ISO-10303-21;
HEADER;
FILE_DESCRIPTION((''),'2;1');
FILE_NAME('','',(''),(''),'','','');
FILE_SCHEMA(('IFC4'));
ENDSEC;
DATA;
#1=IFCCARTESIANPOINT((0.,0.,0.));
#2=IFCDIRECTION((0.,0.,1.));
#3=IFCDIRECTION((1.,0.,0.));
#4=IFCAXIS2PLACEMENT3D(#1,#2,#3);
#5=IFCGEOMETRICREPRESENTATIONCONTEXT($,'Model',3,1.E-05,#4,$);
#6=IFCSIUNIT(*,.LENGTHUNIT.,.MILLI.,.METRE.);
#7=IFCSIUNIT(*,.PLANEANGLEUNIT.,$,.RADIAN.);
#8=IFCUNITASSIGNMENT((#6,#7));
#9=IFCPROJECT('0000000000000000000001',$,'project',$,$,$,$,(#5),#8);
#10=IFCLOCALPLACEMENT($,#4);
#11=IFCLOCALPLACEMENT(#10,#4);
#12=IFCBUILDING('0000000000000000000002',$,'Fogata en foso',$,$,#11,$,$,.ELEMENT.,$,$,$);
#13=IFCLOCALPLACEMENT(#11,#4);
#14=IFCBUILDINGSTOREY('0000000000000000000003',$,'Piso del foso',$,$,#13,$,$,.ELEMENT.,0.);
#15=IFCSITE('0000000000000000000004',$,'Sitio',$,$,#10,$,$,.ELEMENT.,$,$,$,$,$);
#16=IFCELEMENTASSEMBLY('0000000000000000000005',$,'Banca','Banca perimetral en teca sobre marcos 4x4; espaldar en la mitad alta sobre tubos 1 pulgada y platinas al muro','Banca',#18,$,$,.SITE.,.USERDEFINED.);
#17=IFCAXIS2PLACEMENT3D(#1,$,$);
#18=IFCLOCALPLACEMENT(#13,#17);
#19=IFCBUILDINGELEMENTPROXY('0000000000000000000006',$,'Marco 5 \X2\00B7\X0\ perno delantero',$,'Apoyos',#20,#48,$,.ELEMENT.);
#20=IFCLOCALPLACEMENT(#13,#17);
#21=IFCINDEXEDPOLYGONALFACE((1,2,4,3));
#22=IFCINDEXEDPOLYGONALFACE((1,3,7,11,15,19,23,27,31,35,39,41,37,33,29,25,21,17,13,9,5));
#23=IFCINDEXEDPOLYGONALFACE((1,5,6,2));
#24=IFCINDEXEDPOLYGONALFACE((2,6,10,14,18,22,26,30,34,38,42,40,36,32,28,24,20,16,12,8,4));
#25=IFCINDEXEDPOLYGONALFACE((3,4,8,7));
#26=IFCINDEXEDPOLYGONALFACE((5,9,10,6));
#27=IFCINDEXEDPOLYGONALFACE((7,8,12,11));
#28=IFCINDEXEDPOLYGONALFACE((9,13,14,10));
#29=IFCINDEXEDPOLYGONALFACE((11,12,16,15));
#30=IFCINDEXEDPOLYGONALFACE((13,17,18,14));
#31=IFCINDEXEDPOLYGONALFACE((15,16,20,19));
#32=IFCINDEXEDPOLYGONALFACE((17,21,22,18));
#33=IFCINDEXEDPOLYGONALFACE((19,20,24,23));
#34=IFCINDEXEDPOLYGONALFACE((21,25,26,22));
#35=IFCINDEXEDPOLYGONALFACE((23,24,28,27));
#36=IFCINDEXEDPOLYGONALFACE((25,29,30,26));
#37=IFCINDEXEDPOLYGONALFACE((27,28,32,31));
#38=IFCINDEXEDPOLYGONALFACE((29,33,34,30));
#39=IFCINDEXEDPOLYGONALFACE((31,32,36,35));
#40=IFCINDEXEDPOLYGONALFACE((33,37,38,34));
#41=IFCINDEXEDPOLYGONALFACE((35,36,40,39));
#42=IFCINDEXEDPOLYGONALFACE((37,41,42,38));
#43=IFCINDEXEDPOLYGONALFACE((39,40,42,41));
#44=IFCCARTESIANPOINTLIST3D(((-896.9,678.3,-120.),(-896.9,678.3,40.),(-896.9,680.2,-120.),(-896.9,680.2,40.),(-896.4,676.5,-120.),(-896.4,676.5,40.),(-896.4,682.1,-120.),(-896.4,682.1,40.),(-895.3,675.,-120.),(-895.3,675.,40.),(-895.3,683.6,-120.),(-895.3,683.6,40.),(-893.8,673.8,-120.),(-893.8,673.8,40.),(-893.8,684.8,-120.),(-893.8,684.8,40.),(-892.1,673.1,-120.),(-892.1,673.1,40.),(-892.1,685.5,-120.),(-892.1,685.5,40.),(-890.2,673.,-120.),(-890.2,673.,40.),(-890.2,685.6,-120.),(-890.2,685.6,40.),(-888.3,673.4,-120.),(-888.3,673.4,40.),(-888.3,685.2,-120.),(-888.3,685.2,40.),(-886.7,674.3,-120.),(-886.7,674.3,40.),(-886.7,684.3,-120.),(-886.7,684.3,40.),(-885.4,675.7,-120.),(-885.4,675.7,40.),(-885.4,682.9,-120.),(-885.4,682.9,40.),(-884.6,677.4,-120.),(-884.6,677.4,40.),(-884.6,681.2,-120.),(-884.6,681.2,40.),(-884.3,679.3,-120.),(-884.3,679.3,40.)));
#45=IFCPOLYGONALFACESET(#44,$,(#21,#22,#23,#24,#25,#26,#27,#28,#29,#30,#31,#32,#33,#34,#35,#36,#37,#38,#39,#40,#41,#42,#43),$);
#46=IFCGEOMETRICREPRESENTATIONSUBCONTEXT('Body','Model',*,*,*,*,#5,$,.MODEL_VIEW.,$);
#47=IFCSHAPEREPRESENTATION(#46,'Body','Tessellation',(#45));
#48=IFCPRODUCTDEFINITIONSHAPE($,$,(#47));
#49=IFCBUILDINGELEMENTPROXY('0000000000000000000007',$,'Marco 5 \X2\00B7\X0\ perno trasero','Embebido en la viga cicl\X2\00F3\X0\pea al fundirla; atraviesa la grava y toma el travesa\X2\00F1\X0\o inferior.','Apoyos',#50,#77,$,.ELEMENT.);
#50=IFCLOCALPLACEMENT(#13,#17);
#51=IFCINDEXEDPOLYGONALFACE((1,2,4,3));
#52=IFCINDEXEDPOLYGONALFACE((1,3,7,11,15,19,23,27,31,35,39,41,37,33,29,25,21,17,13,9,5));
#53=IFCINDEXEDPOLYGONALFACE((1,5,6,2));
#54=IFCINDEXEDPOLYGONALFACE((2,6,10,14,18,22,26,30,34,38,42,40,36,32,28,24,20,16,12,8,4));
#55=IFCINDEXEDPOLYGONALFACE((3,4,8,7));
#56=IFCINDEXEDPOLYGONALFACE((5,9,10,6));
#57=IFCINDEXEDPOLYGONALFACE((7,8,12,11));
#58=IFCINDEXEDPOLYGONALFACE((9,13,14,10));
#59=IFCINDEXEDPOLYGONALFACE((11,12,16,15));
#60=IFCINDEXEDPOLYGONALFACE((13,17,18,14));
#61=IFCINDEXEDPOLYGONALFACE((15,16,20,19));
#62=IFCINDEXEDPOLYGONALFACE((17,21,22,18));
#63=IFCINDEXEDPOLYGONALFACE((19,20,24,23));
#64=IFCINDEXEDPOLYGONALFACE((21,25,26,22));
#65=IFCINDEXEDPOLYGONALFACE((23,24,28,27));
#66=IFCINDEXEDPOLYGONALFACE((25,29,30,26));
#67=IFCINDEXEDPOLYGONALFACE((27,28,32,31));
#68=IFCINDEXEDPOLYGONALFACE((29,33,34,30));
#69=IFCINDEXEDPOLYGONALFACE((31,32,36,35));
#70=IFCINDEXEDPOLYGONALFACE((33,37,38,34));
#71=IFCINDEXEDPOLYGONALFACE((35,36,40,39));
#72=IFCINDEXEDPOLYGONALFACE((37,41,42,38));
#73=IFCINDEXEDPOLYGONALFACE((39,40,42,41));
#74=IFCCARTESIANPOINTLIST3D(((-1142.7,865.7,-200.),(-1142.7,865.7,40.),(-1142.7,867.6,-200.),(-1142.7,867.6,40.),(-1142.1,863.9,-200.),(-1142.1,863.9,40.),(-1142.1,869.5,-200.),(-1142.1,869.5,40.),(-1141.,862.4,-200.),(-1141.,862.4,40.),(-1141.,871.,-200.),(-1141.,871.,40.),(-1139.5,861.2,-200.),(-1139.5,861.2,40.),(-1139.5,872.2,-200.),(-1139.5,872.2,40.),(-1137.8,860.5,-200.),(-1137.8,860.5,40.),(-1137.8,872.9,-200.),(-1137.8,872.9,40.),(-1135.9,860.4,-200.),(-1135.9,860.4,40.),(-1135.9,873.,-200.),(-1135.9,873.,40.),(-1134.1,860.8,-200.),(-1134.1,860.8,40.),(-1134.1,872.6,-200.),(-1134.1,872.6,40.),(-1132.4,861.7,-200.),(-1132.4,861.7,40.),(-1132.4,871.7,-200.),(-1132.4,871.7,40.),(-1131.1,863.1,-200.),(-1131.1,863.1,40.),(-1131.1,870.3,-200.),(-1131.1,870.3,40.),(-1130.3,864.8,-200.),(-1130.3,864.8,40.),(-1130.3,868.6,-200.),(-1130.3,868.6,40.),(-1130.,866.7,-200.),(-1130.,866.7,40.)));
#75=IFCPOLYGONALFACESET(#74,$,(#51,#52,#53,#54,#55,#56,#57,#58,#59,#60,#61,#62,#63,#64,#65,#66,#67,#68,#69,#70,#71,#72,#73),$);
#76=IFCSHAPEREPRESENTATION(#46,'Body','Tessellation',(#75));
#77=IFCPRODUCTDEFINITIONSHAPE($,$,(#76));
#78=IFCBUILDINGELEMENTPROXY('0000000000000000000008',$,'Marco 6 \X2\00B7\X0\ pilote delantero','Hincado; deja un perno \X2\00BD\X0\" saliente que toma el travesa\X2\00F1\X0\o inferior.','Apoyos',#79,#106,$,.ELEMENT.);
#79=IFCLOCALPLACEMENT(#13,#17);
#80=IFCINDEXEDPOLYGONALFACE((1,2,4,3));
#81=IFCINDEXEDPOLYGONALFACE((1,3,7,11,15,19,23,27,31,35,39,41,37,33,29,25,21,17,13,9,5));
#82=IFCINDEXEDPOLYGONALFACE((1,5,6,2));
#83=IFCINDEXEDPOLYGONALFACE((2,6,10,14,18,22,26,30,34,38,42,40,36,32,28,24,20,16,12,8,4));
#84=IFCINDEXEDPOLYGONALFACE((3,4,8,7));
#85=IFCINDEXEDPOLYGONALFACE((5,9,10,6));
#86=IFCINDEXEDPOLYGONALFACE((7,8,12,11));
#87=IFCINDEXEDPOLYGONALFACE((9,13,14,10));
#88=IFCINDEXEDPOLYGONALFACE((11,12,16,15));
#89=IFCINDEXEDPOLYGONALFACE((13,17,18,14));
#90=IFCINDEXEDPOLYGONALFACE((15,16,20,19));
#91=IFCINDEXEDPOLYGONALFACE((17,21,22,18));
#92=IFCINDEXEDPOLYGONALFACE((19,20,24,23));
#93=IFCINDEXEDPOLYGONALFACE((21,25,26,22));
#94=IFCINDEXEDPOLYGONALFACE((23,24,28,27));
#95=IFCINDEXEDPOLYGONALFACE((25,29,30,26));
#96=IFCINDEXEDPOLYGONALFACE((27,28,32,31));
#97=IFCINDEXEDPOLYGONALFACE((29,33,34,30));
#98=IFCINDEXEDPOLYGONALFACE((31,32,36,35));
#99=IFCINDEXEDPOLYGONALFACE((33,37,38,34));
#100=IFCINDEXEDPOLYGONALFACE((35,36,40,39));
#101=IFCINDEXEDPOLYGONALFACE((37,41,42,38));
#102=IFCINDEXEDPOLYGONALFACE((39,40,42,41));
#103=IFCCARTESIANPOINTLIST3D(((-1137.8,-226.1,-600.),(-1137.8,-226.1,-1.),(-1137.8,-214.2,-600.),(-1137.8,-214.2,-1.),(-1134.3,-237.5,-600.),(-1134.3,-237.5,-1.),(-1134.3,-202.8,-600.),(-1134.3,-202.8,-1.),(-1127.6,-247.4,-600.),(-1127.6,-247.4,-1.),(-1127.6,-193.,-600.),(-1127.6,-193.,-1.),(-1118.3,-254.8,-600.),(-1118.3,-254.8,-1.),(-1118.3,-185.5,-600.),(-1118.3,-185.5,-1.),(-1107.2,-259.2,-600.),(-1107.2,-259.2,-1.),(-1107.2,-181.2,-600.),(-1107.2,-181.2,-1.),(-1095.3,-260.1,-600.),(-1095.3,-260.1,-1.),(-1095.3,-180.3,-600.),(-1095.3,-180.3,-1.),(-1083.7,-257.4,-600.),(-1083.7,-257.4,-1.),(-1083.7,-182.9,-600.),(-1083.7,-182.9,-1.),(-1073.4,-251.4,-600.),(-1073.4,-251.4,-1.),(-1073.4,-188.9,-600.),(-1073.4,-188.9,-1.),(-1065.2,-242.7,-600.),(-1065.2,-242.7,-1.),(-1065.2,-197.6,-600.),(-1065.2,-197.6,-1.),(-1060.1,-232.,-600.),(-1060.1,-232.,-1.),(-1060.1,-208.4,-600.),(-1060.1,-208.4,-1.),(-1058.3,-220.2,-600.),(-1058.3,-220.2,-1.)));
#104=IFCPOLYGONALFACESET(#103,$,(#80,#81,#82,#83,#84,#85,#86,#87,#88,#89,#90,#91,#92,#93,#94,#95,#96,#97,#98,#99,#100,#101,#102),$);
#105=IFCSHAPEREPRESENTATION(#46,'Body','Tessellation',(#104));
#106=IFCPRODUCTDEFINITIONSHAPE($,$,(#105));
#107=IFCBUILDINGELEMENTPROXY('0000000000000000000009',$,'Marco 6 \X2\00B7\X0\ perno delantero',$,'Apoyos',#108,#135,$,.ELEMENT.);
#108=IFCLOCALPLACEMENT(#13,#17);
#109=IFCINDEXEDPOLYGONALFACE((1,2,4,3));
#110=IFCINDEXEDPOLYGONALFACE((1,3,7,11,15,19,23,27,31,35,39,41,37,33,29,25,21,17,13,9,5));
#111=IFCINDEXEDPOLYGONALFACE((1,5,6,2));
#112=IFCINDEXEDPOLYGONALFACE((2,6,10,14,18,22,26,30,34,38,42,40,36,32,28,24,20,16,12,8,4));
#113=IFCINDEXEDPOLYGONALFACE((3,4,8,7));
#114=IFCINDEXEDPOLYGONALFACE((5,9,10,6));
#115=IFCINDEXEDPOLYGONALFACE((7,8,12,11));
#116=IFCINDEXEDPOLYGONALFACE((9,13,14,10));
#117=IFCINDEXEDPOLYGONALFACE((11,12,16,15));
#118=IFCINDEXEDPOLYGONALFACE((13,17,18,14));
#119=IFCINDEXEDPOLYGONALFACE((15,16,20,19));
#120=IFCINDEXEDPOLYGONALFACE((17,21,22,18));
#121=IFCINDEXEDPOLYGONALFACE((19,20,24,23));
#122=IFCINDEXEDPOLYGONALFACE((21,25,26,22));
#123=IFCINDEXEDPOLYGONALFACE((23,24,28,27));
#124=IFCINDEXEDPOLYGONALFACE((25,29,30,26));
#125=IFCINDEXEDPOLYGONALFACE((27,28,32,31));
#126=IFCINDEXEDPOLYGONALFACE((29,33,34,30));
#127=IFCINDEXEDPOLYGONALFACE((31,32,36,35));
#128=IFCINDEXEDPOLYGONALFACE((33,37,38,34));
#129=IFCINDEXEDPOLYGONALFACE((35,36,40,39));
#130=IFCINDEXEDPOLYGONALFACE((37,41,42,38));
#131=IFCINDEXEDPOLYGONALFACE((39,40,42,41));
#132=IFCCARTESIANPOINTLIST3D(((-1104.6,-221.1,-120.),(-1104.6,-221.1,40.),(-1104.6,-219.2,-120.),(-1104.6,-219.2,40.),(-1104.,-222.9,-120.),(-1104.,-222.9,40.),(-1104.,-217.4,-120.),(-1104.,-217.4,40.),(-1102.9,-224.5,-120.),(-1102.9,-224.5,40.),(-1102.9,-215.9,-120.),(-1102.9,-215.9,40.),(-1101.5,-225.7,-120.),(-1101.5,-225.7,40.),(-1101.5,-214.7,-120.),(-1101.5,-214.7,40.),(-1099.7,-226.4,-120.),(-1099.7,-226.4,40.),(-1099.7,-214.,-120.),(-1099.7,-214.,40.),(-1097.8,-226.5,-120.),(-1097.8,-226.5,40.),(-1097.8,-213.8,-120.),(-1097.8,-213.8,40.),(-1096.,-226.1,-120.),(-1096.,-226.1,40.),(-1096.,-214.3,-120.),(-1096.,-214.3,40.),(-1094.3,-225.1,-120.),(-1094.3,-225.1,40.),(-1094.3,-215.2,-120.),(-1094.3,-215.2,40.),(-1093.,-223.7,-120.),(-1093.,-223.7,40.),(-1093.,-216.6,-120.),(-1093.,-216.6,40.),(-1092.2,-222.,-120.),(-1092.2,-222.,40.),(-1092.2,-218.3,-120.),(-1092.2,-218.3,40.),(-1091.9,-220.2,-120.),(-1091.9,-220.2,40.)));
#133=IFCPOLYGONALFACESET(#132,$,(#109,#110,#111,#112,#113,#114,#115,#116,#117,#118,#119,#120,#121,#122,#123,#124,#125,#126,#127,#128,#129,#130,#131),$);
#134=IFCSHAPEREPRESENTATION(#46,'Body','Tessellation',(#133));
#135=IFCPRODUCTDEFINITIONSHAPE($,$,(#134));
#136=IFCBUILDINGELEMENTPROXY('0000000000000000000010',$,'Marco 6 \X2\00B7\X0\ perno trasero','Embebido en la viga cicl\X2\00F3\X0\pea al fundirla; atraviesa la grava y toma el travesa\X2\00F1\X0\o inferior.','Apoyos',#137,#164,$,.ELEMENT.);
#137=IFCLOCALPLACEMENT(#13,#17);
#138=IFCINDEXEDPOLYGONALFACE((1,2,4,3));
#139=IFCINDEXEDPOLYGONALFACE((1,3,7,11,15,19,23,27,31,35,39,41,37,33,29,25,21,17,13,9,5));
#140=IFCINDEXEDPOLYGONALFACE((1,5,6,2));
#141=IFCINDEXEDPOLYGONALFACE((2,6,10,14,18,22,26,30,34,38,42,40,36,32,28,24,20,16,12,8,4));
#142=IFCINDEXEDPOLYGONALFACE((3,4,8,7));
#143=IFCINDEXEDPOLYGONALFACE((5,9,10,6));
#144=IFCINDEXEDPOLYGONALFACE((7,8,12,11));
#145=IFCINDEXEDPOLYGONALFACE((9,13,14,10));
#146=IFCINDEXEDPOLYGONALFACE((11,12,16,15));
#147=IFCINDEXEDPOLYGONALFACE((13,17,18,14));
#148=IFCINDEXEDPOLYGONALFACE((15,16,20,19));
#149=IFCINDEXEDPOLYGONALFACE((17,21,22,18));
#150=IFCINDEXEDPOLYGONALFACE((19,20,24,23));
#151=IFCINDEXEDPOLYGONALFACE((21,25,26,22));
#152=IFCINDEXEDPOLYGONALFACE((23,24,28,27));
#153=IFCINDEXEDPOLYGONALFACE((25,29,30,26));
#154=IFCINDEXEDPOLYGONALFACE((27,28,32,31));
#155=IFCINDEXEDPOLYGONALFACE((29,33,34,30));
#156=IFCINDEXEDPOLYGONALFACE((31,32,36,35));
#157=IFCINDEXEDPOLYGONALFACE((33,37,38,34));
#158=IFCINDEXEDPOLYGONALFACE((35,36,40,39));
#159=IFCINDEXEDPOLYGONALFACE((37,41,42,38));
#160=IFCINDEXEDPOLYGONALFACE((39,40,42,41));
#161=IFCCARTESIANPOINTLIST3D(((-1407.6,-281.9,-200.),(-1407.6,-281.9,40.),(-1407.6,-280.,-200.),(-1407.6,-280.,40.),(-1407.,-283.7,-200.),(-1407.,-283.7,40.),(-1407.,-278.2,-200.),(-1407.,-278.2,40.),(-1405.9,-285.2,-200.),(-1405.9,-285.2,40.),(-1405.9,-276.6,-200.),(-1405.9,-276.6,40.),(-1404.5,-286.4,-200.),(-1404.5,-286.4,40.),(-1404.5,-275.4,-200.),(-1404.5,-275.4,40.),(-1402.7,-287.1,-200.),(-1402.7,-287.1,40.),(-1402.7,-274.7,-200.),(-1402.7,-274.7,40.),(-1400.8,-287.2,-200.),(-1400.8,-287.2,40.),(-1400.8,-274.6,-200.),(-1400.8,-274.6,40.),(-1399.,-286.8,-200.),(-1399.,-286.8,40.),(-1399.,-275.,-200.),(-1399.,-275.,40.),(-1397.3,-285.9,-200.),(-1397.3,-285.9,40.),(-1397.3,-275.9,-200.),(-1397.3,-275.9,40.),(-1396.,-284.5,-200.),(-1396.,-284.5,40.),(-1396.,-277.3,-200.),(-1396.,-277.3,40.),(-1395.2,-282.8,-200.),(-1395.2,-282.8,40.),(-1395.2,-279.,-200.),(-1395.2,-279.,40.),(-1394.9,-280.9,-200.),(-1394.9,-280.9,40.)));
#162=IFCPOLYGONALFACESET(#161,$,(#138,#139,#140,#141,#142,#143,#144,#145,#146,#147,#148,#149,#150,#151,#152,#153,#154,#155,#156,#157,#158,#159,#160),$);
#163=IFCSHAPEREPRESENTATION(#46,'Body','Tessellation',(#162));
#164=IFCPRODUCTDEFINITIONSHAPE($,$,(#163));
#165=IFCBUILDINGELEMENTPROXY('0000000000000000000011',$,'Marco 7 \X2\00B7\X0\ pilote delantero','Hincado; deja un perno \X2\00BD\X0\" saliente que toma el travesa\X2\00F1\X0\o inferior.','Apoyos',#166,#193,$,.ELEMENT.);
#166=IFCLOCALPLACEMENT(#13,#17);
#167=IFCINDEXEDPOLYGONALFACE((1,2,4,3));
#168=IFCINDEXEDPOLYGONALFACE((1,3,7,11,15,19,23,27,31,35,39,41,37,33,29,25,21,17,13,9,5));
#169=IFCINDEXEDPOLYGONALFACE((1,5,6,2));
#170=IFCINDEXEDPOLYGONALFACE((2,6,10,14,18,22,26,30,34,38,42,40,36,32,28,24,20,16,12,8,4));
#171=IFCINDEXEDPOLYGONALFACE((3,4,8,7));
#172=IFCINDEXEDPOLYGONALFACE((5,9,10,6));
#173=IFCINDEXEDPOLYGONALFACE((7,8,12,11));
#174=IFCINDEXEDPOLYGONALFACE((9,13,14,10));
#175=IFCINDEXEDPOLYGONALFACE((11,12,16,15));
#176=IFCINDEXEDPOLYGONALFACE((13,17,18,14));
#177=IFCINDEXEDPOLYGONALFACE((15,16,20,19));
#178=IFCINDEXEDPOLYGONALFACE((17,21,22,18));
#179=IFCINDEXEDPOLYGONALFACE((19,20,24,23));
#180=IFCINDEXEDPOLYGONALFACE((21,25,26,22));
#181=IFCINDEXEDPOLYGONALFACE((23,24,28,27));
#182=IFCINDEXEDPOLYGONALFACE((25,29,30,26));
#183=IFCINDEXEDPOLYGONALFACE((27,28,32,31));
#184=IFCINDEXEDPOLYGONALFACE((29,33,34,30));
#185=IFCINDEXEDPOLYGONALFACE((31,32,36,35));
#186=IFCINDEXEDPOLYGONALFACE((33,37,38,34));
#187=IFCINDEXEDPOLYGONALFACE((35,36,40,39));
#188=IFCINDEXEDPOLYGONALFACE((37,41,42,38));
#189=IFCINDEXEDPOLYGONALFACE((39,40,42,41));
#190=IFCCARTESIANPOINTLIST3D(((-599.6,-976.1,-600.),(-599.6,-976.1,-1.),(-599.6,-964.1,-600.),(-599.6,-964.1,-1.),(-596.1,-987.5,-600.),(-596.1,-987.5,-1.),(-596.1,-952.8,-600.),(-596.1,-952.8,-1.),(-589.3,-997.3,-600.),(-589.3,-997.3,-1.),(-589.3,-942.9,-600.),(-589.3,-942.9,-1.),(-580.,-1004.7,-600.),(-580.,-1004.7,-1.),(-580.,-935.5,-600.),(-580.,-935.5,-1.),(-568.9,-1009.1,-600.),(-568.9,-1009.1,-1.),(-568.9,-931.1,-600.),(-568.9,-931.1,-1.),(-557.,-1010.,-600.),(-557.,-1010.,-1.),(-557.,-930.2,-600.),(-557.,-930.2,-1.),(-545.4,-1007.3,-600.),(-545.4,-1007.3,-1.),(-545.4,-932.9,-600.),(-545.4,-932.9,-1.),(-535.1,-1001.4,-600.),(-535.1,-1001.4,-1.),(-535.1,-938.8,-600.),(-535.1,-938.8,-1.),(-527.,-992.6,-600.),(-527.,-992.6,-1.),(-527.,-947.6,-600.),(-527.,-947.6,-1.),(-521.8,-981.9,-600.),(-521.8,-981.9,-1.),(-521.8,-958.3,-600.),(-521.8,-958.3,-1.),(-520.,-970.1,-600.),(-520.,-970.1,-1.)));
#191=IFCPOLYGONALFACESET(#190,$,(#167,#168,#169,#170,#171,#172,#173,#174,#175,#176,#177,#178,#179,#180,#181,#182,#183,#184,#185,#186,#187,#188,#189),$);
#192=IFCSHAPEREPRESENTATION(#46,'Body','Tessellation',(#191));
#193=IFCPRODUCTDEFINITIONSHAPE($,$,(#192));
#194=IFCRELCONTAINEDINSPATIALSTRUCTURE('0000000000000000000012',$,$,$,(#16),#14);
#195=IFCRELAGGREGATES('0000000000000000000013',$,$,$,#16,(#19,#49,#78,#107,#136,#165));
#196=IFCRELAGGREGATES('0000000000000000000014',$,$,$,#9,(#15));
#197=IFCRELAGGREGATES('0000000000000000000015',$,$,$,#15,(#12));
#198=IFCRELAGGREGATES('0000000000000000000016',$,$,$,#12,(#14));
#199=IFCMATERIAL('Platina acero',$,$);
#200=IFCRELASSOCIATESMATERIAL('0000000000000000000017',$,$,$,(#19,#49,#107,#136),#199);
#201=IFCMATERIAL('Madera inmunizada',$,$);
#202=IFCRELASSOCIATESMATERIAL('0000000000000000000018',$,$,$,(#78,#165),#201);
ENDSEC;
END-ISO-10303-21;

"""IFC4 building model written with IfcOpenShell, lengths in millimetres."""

from ifc_helpers import new_model, si_unit, frame, origin_with_axes, origin_2d, place, context, subcontext, project, spatial, circle, extrude, material, element, aggregate, save


model = new_model("IFC4")

# Units and contexts
model_context = context("Model", 3, precision=1e-05, world=origin_with_axes())
body_context = subcontext(model_context, "Body", "Model", "MODEL_VIEW")
ifc_project = project(units=[si_unit("LENGTHUNIT", "METRE", prefix="MILLI"), si_unit("PLANEANGLEUNIT", "RADIAN")], contexts=[model_context])

# Site, building, storey
site_placement = place(None, origin_with_axes())
site = spatial("IfcSite", under=ifc_project, at=site_placement, Name="Sitio", CompositionType="ELEMENT")
building_placement = place(site_placement, origin_with_axes())
building = spatial("IfcBuilding", under=site, at=building_placement, Name="Fogata en foso", CompositionType="ELEMENT")
storey_placement = place(building_placement, origin_with_axes())
storey = spatial("IfcBuildingStorey", under=building, at=storey_placement, Name="Piso del foso", CompositionType="ELEMENT", Elevation=0.0)

# Element assembly, building element proxies
assembly_1_placement = place(storey_placement, origin_with_axes())
assembly_1 = element("IfcElementAssembly", 1, at=assembly_1_placement, inside=storey, Name="Banca", Description="Banca perimetral en teca sobre marcos 4x4; espaldar en la mitad alta sobre tubos 1 pulgada y platinas al muro", ObjectType="Banca", AssemblyPlace="SITE", PredefinedType="USERDEFINED")
ifc_material_1 = material(Name="Madera inmunizada")
ifc_material_2 = material(Name="Platina acero")
proxy_1_placement = place(storey_placement, frame((-890.7, 679.3, -120.0), z_axis=(0.0, 0.0, 1.0), x_axis=(1.0, 0.0, 0.0)))
proxy_1 = element("IfcBuildingElementProxy", 2, at=proxy_1_placement, material=ifc_material_2, Name="Marco 5 · perno delantero", ObjectType="Apoyos", PredefinedType="ELEMENT", context=body_context, shape_type="SweptSolid", body=[
    extrude(circle(Radius=6.3, at=origin_2d()), origin_with_axes(), (0.0, 0.0, 1.0), 160.0),
])
proxy_2_placement = place(storey_placement, frame((-1136.4, 866.7, -200.0), z_axis=(0.0, 0.0, 1.0), x_axis=(1.0, 0.0, 0.0)))
proxy_2 = element("IfcBuildingElementProxy", 3, at=proxy_2_placement, material=ifc_material_2, Name="Marco 5 · perno trasero", Description="Embebido en la viga ciclópea al fundirla; atraviesa la grava y toma el travesaño inferior.", ObjectType="Apoyos", PredefinedType="ELEMENT", context=body_context, shape_type="SweptSolid", body=[
    extrude(circle(Radius=6.3, at=origin_2d()), origin_with_axes(), (0.0, 0.0, 1.0), 240.0),
])
proxy_3_placement = place(storey_placement, frame((-1098.3, -220.2, -600.0), z_axis=(0.0, 0.0, 1.0), x_axis=(1.0, 0.0, 0.0)))
proxy_3 = element("IfcBuildingElementProxy", 4, at=proxy_3_placement, material=ifc_material_1, Name="Marco 6 · pilote delantero", Description="Hincado; deja un perno ½\" saliente que toma el travesaño inferior.", ObjectType="Apoyos", PredefinedType="ELEMENT", context=body_context, shape_type="SweptSolid", body=[
    extrude(circle(Radius=40.0, at=origin_2d()), origin_with_axes(), (0.0, 0.0, 1.0), 599.0),
])
proxy_4_placement = place(storey_placement, frame((-1098.3, -220.2, -120.0), z_axis=(0.0, 0.0, 1.0), x_axis=(1.0, 0.0, 0.0)))
proxy_4 = element("IfcBuildingElementProxy", 5, at=proxy_4_placement, material=ifc_material_2, Name="Marco 6 · perno delantero", ObjectType="Apoyos", PredefinedType="ELEMENT", context=body_context, shape_type="SweptSolid", body=[
    extrude(circle(Radius=6.3, at=origin_2d()), origin_with_axes(), (0.0, 0.0, 1.0), 160.0),
])
proxy_5_placement = place(storey_placement, frame((-1401.3, -280.9, -200.0), z_axis=(0.0, 0.0, 1.0), x_axis=(1.0, 0.0, 0.0)))
proxy_5 = element("IfcBuildingElementProxy", 6, at=proxy_5_placement, material=ifc_material_2, Name="Marco 6 · perno trasero", Description="Embebido en la viga ciclópea al fundirla; atraviesa la grava y toma el travesaño inferior.", ObjectType="Apoyos", PredefinedType="ELEMENT", context=body_context, shape_type="SweptSolid", body=[
    extrude(circle(Radius=6.3, at=origin_2d()), origin_with_axes(), (0.0, 0.0, 1.0), 240.0),
])
proxy_6_placement = place(storey_placement, frame((-560.0, -970.1, -600.0), z_axis=(0.0, 0.0, 1.0), x_axis=(1.0, 0.0, 0.0)))
proxy_6 = element("IfcBuildingElementProxy", 7, at=proxy_6_placement, material=ifc_material_1, Name="Marco 7 · pilote delantero", Description="Hincado; deja un perno ½\" saliente que toma el travesaño inferior.", ObjectType="Apoyos", PredefinedType="ELEMENT", context=body_context, shape_type="SweptSolid", body=[
    extrude(circle(Radius=40.0, at=origin_2d()), origin_with_axes(), (0.0, 0.0, 1.0), 599.0),
])
aggregate(assembly_1, [proxy_1, proxy_2, proxy_3, proxy_4, proxy_5, proxy_6])

save(model, "model.ifc")
